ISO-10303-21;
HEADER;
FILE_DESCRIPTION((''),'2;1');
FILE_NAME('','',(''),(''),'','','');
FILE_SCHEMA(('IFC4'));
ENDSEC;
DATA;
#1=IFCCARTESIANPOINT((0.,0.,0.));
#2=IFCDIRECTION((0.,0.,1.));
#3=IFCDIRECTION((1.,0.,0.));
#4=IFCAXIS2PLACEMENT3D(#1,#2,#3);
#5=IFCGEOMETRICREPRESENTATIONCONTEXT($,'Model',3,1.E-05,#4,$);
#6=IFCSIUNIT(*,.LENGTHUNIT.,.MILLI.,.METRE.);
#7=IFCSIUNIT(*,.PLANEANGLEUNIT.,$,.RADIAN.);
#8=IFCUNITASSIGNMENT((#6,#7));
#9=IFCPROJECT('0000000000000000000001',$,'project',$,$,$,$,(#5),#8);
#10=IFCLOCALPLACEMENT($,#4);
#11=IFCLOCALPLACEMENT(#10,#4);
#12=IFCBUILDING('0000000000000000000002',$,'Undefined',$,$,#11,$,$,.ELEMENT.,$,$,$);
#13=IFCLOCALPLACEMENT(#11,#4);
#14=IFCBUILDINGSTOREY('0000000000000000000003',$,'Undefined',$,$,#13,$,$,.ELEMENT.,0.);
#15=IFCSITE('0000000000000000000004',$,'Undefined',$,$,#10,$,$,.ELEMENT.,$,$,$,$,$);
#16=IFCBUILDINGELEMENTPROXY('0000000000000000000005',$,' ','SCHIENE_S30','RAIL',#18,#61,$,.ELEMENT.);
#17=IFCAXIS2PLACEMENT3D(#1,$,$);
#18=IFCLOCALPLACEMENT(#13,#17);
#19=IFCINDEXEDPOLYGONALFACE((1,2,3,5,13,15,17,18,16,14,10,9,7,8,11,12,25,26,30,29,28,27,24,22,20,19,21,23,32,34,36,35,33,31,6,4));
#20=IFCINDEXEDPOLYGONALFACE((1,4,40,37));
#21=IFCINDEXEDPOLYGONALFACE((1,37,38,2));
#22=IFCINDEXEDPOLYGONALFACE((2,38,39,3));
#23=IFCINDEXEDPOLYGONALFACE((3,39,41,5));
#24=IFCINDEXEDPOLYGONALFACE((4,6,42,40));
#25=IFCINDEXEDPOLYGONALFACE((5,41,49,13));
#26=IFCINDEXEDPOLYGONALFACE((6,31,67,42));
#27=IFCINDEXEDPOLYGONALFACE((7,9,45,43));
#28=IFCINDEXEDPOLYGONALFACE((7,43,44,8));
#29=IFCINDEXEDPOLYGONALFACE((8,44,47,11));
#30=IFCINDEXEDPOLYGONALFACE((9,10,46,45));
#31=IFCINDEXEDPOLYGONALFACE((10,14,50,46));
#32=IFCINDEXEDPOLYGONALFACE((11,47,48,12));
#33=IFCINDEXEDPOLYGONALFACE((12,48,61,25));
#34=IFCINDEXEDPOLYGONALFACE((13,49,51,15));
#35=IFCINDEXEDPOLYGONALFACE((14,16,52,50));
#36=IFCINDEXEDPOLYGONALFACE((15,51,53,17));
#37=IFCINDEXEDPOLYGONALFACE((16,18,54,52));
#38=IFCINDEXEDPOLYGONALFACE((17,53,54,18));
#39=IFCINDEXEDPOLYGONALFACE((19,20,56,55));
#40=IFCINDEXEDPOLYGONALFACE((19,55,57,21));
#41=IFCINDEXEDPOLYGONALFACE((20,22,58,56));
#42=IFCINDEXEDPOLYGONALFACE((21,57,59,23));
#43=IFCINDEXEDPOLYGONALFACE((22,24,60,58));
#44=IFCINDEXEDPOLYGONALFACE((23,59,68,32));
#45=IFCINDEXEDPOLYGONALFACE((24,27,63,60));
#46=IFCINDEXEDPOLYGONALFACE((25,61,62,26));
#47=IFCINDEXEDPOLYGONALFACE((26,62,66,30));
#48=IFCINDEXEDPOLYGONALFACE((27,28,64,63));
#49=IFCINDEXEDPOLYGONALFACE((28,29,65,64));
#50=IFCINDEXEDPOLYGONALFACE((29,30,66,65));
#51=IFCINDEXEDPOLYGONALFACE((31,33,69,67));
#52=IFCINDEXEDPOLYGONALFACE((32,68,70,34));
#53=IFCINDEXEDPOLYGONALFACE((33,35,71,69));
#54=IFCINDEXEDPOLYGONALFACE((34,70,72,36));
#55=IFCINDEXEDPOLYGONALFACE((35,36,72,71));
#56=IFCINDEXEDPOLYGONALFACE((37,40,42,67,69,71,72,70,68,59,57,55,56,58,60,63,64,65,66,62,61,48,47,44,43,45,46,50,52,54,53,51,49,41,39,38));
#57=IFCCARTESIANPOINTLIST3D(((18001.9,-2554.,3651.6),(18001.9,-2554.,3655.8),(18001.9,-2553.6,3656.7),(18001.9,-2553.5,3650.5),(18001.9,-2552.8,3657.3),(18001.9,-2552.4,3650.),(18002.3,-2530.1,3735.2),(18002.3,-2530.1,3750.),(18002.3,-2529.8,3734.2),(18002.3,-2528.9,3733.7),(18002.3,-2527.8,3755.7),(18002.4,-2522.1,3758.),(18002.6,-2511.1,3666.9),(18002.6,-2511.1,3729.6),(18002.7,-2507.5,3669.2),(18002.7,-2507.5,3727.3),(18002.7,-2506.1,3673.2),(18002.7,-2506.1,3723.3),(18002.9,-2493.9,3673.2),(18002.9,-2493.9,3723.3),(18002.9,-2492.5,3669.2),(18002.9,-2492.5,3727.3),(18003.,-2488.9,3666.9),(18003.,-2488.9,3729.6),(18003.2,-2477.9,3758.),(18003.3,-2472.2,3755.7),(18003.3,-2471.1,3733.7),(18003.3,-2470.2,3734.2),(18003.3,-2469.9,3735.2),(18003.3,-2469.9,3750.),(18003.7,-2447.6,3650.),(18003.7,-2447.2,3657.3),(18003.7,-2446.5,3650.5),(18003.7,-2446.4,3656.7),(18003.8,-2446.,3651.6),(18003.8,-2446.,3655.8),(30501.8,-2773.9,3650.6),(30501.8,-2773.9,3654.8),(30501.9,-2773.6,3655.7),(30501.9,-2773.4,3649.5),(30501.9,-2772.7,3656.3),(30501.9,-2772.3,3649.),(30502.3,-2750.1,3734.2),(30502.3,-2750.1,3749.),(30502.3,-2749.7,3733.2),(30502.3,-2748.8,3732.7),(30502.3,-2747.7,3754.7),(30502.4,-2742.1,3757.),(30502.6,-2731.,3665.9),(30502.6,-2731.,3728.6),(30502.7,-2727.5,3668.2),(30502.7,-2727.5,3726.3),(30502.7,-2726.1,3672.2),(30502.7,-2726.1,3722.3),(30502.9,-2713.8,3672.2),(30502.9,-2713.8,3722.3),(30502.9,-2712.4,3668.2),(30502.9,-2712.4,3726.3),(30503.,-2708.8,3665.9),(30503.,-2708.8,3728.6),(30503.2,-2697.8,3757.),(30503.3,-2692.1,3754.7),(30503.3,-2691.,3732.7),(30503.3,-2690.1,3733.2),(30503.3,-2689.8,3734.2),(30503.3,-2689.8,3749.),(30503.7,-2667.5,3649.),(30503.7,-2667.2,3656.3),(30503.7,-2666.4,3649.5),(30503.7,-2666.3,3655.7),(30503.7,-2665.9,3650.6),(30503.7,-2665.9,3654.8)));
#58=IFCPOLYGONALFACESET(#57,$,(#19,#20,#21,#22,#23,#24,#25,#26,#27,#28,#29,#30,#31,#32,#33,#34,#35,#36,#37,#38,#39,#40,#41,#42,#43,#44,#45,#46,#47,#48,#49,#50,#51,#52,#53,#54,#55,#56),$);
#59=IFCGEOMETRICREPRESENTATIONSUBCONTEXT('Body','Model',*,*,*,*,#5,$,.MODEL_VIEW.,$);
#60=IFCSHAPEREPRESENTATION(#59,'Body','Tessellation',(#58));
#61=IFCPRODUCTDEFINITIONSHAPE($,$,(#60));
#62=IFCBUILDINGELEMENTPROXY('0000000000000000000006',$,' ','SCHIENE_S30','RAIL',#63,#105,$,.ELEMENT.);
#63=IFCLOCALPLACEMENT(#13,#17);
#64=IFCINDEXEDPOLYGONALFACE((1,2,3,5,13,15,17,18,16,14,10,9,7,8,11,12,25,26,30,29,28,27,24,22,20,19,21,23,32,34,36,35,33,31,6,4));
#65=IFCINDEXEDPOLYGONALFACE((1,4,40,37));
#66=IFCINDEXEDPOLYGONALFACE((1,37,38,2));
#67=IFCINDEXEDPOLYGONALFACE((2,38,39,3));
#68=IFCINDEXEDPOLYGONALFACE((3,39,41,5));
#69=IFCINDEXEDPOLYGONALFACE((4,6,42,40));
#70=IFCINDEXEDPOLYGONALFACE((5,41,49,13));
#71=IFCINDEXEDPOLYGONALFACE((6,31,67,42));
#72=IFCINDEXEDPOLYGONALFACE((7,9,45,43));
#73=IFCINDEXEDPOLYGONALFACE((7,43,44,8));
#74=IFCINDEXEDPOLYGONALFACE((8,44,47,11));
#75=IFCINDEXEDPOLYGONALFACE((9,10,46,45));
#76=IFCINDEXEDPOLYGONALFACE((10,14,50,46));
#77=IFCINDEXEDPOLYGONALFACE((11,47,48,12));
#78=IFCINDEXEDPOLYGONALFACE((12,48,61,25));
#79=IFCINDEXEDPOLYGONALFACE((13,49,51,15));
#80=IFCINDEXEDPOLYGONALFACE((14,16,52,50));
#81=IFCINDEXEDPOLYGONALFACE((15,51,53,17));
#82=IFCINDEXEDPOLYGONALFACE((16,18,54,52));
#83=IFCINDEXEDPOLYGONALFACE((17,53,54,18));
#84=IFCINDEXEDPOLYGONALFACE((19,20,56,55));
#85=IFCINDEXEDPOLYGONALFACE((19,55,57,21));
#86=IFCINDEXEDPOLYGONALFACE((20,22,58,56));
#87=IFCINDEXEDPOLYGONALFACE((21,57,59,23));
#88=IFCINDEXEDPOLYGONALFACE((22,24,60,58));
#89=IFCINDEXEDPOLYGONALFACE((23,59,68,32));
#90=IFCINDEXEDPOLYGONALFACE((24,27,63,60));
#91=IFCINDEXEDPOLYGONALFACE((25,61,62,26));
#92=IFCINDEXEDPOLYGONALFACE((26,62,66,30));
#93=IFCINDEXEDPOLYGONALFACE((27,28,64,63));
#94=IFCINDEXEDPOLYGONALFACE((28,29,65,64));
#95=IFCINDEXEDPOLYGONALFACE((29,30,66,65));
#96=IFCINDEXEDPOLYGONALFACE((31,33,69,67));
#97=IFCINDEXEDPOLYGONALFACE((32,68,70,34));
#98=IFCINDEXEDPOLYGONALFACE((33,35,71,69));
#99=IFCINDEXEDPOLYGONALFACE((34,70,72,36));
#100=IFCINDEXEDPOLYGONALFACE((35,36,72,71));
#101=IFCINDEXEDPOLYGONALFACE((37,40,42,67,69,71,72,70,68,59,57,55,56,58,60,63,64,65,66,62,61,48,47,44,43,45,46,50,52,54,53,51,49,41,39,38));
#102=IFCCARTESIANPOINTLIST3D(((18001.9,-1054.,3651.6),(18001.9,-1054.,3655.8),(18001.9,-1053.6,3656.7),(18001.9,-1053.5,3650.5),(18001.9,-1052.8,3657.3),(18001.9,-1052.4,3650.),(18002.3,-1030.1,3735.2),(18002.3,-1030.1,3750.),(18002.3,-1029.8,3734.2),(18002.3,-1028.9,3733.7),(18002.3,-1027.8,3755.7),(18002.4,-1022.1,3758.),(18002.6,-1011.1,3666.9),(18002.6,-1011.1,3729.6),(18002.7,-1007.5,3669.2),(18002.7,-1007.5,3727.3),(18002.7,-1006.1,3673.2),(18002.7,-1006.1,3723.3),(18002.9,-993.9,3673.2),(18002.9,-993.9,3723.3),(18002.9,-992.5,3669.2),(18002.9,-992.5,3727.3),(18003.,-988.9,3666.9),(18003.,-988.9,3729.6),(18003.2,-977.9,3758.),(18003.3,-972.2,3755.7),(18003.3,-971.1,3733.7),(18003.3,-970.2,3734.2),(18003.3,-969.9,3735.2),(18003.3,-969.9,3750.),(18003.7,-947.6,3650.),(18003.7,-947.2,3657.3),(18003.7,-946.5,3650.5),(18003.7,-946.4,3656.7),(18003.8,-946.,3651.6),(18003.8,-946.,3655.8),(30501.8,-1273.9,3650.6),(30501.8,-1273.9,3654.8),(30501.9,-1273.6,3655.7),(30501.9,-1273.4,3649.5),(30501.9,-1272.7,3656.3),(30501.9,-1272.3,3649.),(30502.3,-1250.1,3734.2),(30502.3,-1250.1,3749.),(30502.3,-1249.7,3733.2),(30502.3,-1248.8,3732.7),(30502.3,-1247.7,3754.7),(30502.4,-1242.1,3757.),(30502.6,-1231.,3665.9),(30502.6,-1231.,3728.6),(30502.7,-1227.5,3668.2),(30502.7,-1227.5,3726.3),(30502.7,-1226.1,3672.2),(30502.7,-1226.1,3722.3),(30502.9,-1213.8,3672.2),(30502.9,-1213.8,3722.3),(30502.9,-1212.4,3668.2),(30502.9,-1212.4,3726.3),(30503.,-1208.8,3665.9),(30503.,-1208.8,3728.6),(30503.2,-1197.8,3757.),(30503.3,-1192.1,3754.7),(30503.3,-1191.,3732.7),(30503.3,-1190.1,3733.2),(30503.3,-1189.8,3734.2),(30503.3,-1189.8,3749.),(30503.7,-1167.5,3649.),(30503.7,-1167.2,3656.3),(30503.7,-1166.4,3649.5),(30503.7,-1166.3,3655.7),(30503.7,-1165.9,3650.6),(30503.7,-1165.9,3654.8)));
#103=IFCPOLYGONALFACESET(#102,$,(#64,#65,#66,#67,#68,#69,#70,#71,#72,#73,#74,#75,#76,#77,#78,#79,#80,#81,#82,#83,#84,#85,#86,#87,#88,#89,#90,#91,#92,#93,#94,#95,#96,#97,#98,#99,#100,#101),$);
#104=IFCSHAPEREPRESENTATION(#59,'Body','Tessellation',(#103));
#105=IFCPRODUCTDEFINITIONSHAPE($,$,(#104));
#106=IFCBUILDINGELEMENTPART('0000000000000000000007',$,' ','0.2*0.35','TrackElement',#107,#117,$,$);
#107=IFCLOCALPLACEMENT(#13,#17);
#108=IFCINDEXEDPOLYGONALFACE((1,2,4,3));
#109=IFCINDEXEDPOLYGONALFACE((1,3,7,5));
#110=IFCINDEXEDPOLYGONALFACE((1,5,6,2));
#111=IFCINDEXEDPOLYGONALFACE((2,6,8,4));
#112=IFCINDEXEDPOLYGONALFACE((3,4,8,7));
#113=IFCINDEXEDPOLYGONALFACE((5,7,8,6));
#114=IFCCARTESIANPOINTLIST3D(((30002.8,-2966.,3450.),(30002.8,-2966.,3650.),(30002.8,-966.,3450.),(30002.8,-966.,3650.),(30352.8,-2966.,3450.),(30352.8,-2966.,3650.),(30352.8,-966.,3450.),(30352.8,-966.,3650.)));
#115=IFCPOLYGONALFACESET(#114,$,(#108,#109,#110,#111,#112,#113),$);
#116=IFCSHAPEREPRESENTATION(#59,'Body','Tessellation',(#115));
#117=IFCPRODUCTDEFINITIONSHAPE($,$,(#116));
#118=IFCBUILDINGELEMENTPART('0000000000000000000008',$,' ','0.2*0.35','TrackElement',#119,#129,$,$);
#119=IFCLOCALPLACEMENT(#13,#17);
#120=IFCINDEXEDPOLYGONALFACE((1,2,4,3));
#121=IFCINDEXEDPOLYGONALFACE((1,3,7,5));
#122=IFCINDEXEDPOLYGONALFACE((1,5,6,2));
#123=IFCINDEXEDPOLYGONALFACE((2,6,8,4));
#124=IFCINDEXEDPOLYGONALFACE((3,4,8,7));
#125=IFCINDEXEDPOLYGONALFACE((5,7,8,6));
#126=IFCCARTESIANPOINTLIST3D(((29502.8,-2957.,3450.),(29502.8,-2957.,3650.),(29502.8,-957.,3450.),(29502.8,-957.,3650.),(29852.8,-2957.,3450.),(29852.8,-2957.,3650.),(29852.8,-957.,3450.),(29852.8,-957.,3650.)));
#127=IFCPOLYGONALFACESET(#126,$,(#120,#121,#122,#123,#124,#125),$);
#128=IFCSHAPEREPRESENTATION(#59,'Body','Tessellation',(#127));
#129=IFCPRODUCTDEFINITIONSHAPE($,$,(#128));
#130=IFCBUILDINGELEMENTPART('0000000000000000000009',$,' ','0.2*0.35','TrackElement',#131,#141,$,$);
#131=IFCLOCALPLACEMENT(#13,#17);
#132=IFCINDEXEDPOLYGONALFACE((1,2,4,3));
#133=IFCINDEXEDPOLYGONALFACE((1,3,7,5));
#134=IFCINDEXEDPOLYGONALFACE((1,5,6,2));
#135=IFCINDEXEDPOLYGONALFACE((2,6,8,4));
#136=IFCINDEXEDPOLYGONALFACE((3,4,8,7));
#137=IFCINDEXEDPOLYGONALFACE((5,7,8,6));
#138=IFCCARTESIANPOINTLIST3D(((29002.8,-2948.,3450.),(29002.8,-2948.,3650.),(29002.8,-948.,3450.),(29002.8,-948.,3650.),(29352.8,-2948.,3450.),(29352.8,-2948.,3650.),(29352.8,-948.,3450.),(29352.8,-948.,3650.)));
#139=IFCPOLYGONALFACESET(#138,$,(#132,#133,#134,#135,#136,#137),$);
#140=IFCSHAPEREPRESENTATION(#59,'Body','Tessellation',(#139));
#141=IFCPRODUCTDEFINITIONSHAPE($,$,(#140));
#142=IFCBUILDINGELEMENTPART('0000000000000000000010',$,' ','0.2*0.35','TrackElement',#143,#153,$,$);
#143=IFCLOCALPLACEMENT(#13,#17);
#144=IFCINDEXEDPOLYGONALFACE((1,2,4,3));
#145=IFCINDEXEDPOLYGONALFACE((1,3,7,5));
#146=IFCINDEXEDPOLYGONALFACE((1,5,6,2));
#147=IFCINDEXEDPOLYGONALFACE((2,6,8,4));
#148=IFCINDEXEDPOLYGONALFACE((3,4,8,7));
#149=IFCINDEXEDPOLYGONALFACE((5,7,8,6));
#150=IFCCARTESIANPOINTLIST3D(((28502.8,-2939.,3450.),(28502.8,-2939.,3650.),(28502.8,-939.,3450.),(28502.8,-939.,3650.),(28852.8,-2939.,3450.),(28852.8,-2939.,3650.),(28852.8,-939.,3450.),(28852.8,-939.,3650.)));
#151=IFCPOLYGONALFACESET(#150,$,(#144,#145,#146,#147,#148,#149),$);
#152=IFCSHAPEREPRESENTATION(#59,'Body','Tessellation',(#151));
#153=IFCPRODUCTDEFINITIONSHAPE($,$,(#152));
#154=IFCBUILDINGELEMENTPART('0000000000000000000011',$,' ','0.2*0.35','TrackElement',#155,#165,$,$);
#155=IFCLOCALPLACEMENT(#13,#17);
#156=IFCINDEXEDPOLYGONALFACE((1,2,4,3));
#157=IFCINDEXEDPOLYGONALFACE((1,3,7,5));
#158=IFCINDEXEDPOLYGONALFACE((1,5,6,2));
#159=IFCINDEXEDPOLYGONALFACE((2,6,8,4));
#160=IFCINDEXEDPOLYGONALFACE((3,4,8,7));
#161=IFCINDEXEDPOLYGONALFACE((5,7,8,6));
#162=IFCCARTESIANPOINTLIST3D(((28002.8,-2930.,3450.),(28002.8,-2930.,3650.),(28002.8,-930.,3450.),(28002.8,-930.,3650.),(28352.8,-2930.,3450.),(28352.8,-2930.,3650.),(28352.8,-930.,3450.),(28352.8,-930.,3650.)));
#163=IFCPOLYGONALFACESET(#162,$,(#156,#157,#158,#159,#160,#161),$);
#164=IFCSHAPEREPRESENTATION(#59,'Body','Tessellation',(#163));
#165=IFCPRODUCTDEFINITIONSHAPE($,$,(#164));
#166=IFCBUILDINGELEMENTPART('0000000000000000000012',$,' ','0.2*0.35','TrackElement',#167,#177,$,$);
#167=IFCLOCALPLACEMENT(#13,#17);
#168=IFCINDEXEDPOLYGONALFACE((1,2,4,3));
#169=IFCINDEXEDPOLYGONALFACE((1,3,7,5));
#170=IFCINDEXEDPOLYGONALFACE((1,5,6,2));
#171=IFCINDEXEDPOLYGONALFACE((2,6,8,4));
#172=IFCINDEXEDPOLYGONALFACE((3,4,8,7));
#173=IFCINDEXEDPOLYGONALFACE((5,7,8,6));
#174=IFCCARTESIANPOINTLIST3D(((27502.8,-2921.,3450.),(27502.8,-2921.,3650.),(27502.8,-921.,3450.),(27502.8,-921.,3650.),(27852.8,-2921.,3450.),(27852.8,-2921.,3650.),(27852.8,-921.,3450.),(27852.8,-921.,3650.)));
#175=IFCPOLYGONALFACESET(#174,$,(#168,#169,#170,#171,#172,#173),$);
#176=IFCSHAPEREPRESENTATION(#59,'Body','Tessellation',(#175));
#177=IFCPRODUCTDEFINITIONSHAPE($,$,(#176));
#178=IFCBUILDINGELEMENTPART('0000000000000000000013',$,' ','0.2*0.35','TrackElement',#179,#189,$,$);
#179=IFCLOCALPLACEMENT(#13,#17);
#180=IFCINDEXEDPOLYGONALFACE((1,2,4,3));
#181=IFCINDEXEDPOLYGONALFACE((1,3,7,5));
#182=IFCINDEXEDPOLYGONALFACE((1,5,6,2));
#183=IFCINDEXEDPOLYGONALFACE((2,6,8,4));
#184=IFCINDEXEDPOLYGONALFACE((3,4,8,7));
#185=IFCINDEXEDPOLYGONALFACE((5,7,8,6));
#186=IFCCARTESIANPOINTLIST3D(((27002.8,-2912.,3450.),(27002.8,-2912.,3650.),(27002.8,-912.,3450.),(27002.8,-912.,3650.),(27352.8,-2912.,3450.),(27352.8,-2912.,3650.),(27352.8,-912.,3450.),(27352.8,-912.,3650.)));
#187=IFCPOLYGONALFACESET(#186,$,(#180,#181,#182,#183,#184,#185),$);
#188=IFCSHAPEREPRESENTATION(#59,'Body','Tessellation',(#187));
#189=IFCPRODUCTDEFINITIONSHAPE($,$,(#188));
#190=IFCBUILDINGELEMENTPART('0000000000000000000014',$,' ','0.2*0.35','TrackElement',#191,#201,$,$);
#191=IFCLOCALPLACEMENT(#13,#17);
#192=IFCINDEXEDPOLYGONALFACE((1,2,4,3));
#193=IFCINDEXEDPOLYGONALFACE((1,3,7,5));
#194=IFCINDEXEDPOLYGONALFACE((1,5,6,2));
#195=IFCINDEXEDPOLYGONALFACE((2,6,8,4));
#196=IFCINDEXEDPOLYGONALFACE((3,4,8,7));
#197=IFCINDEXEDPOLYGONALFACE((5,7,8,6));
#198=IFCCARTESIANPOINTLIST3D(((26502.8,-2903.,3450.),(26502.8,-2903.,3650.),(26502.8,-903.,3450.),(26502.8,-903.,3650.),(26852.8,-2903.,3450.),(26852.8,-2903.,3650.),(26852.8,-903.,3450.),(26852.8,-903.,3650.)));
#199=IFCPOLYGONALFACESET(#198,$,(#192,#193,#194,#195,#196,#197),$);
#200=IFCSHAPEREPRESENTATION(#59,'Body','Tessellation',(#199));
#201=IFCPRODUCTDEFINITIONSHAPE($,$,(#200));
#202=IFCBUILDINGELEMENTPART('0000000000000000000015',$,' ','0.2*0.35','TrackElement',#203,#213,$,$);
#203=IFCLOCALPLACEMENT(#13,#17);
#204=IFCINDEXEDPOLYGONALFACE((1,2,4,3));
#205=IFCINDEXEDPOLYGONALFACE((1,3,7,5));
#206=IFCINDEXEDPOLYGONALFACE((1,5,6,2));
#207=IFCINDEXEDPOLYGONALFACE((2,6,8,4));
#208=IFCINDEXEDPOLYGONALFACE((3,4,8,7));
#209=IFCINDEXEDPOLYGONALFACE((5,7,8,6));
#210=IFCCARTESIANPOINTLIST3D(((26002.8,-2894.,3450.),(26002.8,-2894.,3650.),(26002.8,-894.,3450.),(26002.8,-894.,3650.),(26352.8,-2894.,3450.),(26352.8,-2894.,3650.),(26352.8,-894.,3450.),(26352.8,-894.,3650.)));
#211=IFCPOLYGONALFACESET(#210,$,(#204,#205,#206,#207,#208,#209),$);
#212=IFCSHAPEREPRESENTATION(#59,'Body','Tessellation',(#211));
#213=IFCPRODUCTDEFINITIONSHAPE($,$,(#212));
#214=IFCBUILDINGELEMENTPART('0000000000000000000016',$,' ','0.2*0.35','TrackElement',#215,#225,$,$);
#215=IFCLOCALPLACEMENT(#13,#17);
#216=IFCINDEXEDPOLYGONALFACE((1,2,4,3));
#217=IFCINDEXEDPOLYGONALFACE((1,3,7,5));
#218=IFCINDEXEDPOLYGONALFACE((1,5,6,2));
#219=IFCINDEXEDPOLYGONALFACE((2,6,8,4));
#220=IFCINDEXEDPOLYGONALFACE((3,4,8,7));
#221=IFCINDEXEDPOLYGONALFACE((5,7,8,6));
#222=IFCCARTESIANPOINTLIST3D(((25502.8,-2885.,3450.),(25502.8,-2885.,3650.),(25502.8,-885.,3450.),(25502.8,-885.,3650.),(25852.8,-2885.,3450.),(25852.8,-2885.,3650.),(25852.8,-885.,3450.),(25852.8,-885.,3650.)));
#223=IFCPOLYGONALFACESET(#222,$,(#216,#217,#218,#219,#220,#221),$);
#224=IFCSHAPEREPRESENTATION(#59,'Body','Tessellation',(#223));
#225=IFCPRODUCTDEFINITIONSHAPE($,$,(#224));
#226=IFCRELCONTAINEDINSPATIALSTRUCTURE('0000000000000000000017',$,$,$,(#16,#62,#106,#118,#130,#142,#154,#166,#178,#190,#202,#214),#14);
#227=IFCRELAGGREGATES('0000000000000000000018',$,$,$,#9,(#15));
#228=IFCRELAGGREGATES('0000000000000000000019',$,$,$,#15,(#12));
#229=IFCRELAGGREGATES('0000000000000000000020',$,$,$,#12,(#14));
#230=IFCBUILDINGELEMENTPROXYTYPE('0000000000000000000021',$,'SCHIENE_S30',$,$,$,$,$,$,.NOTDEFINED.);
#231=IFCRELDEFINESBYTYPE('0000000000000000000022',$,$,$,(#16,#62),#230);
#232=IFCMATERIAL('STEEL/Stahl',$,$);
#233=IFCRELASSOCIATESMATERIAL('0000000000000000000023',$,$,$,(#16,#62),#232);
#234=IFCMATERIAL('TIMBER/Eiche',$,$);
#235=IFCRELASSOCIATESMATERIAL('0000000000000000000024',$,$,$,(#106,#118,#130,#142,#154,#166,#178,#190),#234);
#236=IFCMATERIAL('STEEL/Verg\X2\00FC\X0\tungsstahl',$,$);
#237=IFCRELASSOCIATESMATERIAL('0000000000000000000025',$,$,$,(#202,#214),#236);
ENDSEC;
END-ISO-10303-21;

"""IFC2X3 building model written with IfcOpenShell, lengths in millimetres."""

from ifc_helpers import new_model, si_unit, frame, origin_with_axes, origin_2d_with_axis, place, context, subcontext, project, spatial, polyline, rectangle, outline, extrude, material, type_object, element, save


model = new_model("IFC2X3")

# Units and contexts
model_context = context("Model", 3, precision=1e-05, world=origin_with_axes())
body_context = subcontext(model_context, "Body", "Model", "MODEL_VIEW")
ifc_project = project(units=[si_unit("LENGTHUNIT", "METRE", prefix="MILLI"), si_unit("PLANEANGLEUNIT", "RADIAN")], contexts=[model_context])

# Site, building, storey
site_placement = place(None, origin_with_axes())
site = spatial("IfcSite", under=ifc_project, at=site_placement, Name="Undefined", CompositionType="ELEMENT")
building_placement = place(site_placement, origin_with_axes())
building = spatial("IfcBuilding", under=site, at=building_placement, Name="Undefined", CompositionType="ELEMENT")
storey_placement = place(building_placement, origin_with_axes())
storey = spatial("IfcBuildingStorey", under=building, at=storey_placement, Name="Undefined", CompositionType="ELEMENT", Elevation=0.0)

# Building element proxies
ifc_material_1 = material(Name="STEEL/Stahl")
building_element_proxy_type = type_object("IfcBuildingElementProxyType", Name="SCHIENE_S30", PredefinedType="NOTDEFINED")
for number, where, z_axis, x_axis, name in (
    (1, (18002.8, -2500.0, 3704.0), (0.00008, -0.000001, 1.0), (0.999845, -0.017591, -0.00008), " "),
    (2, (18002.8, -1000.0, 3704.0), (0.00008, -0.000001, 1.0), (0.999845, -0.017591, -0.00008), " "),
):
    element("IfcBuildingElementProxy", number, at=place(storey_placement, frame(where, z_axis=z_axis, x_axis=x_axis)), inside=storey, type_object=building_element_proxy_type, material=ifc_material_1, Name=name, Description="SCHIENE_S30", ObjectType="RAIL", CompositionType="ELEMENT", context=body_context, shape_type="SweptSolid", body=[
        extrude(outline(polyline([(-53.5, -53.5), (-54.0, -52.4), (-54.0, -48.2), (-53.7, -47.2), (-52.8, -46.7), (-11.1, -37.1), (-7.5, -34.8), (-6.2, -30.8), (-6.2, 19.3), (-7.5, 23.3), (-11.1, 25.6), (-28.9, 29.7), (-29.8, 30.2), (-30.1, 31.2), (-30.1, 46.0), (-27.8, 51.7), (-22.1, 54.0), (22.1, 54.0), (27.8, 51.7), (30.1, 46.0), (30.1, 31.2), (29.8, 30.2), (28.9, 29.7), (11.1, 25.6), (7.5, 23.3), (6.2, 19.3), (6.2, -30.8), (7.5, -34.8), (11.1, -37.1), (52.8, -46.7), (53.7, -47.2), (54.0, -48.2), (54.0, -52.4), (53.5, -53.5), (52.4, -54.0), (-52.4, -54.0), (-53.5, -53.5)])), frame((12501.9, 0.0, 0.0), z_axis=(-1.0, 0.0, 0.0), x_axis=(0.0, -1.0, 0.0)), (0.0, 0.0, 1.0), 12501.9),
    ])

# Building element parts
ifc_material_2 = material(Name="TIMBER/Eiche")
for number, where, z_axis, x_axis, name in (
    (3, (30177.8, -966.0, 3550.0), (0.0, 0.0, 1.0), (0.0, -1.0, 0.0), " "),
    (4, (29677.8, -957.0, 3550.0), (0.0, 0.0, 1.0), (0.0, -1.0, 0.0), " "),
    (5, (29177.8, -948.0, 3550.0), (0.0, 0.0, 1.0), (0.0, -1.0, 0.0), " "),
    (6, (28677.8, -939.0, 3550.0), (0.0, 0.0, 1.0), (0.0, -1.0, 0.0), " "),
    (7, (28177.8, -930.0, 3550.0), (0.0, 0.0, 1.0), (0.0, -1.0, 0.0), " "),
    (8, (27677.8, -921.0, 3550.0), (0.0, 0.0, 1.0), (0.0, -1.0, 0.0), " "),
    (9, (27177.8, -912.0, 3550.0), (0.0, 0.0, 1.0), (0.0, -1.0, 0.0), " "),
    (10, (26677.8, -903.0, 3550.0), (0.0, 0.0, 1.0), (0.0, -1.0, 0.0), " "),
):
    element("IfcBuildingElementPart", number, at=place(storey_placement, frame(where, z_axis=z_axis, x_axis=x_axis)), inside=storey, material=ifc_material_2, Name=name, Description="0.2*0.35", ObjectType="TrackElement", context=body_context, shape_type="SweptSolid", body=[
        extrude(rectangle(XDim=350.0, YDim=200.0, at=origin_2d_with_axis()), frame((2000.0, 0.0, 0.0), z_axis=(-1.0, 0.0, 0.0), x_axis=(0.0, -1.0, 0.0)), (0.0, 0.0, 1.0), 2000.0),
    ])
ifc_material_3 = material(Name="STEEL/Vergütungsstahl")
for number, where, z_axis, x_axis, name in (
    (11, (26177.8, -894.0, 3550.0), (0.0, 0.0, 1.0), (0.0, -1.0, 0.0), " "),
    (12, (25677.8, -885.0, 3550.0), (0.0, 0.0, 1.0), (0.0, -1.0, 0.0), " "),
):
    element("IfcBuildingElementPart", number, at=place(storey_placement, frame(where, z_axis=z_axis, x_axis=x_axis)), inside=storey, material=ifc_material_3, Name=name, Description="0.2*0.35", ObjectType="TrackElement", context=body_context, shape_type="SweptSolid", body=[
        extrude(rectangle(XDim=350.0, YDim=200.0, at=origin_2d_with_axis()), frame((2000.0, 0.0, 0.0), z_axis=(-1.0, 0.0, 0.0), x_axis=(0.0, -1.0, 0.0)), (0.0, 0.0, 1.0), 2000.0),
    ])

save(model, "model.ifc")
